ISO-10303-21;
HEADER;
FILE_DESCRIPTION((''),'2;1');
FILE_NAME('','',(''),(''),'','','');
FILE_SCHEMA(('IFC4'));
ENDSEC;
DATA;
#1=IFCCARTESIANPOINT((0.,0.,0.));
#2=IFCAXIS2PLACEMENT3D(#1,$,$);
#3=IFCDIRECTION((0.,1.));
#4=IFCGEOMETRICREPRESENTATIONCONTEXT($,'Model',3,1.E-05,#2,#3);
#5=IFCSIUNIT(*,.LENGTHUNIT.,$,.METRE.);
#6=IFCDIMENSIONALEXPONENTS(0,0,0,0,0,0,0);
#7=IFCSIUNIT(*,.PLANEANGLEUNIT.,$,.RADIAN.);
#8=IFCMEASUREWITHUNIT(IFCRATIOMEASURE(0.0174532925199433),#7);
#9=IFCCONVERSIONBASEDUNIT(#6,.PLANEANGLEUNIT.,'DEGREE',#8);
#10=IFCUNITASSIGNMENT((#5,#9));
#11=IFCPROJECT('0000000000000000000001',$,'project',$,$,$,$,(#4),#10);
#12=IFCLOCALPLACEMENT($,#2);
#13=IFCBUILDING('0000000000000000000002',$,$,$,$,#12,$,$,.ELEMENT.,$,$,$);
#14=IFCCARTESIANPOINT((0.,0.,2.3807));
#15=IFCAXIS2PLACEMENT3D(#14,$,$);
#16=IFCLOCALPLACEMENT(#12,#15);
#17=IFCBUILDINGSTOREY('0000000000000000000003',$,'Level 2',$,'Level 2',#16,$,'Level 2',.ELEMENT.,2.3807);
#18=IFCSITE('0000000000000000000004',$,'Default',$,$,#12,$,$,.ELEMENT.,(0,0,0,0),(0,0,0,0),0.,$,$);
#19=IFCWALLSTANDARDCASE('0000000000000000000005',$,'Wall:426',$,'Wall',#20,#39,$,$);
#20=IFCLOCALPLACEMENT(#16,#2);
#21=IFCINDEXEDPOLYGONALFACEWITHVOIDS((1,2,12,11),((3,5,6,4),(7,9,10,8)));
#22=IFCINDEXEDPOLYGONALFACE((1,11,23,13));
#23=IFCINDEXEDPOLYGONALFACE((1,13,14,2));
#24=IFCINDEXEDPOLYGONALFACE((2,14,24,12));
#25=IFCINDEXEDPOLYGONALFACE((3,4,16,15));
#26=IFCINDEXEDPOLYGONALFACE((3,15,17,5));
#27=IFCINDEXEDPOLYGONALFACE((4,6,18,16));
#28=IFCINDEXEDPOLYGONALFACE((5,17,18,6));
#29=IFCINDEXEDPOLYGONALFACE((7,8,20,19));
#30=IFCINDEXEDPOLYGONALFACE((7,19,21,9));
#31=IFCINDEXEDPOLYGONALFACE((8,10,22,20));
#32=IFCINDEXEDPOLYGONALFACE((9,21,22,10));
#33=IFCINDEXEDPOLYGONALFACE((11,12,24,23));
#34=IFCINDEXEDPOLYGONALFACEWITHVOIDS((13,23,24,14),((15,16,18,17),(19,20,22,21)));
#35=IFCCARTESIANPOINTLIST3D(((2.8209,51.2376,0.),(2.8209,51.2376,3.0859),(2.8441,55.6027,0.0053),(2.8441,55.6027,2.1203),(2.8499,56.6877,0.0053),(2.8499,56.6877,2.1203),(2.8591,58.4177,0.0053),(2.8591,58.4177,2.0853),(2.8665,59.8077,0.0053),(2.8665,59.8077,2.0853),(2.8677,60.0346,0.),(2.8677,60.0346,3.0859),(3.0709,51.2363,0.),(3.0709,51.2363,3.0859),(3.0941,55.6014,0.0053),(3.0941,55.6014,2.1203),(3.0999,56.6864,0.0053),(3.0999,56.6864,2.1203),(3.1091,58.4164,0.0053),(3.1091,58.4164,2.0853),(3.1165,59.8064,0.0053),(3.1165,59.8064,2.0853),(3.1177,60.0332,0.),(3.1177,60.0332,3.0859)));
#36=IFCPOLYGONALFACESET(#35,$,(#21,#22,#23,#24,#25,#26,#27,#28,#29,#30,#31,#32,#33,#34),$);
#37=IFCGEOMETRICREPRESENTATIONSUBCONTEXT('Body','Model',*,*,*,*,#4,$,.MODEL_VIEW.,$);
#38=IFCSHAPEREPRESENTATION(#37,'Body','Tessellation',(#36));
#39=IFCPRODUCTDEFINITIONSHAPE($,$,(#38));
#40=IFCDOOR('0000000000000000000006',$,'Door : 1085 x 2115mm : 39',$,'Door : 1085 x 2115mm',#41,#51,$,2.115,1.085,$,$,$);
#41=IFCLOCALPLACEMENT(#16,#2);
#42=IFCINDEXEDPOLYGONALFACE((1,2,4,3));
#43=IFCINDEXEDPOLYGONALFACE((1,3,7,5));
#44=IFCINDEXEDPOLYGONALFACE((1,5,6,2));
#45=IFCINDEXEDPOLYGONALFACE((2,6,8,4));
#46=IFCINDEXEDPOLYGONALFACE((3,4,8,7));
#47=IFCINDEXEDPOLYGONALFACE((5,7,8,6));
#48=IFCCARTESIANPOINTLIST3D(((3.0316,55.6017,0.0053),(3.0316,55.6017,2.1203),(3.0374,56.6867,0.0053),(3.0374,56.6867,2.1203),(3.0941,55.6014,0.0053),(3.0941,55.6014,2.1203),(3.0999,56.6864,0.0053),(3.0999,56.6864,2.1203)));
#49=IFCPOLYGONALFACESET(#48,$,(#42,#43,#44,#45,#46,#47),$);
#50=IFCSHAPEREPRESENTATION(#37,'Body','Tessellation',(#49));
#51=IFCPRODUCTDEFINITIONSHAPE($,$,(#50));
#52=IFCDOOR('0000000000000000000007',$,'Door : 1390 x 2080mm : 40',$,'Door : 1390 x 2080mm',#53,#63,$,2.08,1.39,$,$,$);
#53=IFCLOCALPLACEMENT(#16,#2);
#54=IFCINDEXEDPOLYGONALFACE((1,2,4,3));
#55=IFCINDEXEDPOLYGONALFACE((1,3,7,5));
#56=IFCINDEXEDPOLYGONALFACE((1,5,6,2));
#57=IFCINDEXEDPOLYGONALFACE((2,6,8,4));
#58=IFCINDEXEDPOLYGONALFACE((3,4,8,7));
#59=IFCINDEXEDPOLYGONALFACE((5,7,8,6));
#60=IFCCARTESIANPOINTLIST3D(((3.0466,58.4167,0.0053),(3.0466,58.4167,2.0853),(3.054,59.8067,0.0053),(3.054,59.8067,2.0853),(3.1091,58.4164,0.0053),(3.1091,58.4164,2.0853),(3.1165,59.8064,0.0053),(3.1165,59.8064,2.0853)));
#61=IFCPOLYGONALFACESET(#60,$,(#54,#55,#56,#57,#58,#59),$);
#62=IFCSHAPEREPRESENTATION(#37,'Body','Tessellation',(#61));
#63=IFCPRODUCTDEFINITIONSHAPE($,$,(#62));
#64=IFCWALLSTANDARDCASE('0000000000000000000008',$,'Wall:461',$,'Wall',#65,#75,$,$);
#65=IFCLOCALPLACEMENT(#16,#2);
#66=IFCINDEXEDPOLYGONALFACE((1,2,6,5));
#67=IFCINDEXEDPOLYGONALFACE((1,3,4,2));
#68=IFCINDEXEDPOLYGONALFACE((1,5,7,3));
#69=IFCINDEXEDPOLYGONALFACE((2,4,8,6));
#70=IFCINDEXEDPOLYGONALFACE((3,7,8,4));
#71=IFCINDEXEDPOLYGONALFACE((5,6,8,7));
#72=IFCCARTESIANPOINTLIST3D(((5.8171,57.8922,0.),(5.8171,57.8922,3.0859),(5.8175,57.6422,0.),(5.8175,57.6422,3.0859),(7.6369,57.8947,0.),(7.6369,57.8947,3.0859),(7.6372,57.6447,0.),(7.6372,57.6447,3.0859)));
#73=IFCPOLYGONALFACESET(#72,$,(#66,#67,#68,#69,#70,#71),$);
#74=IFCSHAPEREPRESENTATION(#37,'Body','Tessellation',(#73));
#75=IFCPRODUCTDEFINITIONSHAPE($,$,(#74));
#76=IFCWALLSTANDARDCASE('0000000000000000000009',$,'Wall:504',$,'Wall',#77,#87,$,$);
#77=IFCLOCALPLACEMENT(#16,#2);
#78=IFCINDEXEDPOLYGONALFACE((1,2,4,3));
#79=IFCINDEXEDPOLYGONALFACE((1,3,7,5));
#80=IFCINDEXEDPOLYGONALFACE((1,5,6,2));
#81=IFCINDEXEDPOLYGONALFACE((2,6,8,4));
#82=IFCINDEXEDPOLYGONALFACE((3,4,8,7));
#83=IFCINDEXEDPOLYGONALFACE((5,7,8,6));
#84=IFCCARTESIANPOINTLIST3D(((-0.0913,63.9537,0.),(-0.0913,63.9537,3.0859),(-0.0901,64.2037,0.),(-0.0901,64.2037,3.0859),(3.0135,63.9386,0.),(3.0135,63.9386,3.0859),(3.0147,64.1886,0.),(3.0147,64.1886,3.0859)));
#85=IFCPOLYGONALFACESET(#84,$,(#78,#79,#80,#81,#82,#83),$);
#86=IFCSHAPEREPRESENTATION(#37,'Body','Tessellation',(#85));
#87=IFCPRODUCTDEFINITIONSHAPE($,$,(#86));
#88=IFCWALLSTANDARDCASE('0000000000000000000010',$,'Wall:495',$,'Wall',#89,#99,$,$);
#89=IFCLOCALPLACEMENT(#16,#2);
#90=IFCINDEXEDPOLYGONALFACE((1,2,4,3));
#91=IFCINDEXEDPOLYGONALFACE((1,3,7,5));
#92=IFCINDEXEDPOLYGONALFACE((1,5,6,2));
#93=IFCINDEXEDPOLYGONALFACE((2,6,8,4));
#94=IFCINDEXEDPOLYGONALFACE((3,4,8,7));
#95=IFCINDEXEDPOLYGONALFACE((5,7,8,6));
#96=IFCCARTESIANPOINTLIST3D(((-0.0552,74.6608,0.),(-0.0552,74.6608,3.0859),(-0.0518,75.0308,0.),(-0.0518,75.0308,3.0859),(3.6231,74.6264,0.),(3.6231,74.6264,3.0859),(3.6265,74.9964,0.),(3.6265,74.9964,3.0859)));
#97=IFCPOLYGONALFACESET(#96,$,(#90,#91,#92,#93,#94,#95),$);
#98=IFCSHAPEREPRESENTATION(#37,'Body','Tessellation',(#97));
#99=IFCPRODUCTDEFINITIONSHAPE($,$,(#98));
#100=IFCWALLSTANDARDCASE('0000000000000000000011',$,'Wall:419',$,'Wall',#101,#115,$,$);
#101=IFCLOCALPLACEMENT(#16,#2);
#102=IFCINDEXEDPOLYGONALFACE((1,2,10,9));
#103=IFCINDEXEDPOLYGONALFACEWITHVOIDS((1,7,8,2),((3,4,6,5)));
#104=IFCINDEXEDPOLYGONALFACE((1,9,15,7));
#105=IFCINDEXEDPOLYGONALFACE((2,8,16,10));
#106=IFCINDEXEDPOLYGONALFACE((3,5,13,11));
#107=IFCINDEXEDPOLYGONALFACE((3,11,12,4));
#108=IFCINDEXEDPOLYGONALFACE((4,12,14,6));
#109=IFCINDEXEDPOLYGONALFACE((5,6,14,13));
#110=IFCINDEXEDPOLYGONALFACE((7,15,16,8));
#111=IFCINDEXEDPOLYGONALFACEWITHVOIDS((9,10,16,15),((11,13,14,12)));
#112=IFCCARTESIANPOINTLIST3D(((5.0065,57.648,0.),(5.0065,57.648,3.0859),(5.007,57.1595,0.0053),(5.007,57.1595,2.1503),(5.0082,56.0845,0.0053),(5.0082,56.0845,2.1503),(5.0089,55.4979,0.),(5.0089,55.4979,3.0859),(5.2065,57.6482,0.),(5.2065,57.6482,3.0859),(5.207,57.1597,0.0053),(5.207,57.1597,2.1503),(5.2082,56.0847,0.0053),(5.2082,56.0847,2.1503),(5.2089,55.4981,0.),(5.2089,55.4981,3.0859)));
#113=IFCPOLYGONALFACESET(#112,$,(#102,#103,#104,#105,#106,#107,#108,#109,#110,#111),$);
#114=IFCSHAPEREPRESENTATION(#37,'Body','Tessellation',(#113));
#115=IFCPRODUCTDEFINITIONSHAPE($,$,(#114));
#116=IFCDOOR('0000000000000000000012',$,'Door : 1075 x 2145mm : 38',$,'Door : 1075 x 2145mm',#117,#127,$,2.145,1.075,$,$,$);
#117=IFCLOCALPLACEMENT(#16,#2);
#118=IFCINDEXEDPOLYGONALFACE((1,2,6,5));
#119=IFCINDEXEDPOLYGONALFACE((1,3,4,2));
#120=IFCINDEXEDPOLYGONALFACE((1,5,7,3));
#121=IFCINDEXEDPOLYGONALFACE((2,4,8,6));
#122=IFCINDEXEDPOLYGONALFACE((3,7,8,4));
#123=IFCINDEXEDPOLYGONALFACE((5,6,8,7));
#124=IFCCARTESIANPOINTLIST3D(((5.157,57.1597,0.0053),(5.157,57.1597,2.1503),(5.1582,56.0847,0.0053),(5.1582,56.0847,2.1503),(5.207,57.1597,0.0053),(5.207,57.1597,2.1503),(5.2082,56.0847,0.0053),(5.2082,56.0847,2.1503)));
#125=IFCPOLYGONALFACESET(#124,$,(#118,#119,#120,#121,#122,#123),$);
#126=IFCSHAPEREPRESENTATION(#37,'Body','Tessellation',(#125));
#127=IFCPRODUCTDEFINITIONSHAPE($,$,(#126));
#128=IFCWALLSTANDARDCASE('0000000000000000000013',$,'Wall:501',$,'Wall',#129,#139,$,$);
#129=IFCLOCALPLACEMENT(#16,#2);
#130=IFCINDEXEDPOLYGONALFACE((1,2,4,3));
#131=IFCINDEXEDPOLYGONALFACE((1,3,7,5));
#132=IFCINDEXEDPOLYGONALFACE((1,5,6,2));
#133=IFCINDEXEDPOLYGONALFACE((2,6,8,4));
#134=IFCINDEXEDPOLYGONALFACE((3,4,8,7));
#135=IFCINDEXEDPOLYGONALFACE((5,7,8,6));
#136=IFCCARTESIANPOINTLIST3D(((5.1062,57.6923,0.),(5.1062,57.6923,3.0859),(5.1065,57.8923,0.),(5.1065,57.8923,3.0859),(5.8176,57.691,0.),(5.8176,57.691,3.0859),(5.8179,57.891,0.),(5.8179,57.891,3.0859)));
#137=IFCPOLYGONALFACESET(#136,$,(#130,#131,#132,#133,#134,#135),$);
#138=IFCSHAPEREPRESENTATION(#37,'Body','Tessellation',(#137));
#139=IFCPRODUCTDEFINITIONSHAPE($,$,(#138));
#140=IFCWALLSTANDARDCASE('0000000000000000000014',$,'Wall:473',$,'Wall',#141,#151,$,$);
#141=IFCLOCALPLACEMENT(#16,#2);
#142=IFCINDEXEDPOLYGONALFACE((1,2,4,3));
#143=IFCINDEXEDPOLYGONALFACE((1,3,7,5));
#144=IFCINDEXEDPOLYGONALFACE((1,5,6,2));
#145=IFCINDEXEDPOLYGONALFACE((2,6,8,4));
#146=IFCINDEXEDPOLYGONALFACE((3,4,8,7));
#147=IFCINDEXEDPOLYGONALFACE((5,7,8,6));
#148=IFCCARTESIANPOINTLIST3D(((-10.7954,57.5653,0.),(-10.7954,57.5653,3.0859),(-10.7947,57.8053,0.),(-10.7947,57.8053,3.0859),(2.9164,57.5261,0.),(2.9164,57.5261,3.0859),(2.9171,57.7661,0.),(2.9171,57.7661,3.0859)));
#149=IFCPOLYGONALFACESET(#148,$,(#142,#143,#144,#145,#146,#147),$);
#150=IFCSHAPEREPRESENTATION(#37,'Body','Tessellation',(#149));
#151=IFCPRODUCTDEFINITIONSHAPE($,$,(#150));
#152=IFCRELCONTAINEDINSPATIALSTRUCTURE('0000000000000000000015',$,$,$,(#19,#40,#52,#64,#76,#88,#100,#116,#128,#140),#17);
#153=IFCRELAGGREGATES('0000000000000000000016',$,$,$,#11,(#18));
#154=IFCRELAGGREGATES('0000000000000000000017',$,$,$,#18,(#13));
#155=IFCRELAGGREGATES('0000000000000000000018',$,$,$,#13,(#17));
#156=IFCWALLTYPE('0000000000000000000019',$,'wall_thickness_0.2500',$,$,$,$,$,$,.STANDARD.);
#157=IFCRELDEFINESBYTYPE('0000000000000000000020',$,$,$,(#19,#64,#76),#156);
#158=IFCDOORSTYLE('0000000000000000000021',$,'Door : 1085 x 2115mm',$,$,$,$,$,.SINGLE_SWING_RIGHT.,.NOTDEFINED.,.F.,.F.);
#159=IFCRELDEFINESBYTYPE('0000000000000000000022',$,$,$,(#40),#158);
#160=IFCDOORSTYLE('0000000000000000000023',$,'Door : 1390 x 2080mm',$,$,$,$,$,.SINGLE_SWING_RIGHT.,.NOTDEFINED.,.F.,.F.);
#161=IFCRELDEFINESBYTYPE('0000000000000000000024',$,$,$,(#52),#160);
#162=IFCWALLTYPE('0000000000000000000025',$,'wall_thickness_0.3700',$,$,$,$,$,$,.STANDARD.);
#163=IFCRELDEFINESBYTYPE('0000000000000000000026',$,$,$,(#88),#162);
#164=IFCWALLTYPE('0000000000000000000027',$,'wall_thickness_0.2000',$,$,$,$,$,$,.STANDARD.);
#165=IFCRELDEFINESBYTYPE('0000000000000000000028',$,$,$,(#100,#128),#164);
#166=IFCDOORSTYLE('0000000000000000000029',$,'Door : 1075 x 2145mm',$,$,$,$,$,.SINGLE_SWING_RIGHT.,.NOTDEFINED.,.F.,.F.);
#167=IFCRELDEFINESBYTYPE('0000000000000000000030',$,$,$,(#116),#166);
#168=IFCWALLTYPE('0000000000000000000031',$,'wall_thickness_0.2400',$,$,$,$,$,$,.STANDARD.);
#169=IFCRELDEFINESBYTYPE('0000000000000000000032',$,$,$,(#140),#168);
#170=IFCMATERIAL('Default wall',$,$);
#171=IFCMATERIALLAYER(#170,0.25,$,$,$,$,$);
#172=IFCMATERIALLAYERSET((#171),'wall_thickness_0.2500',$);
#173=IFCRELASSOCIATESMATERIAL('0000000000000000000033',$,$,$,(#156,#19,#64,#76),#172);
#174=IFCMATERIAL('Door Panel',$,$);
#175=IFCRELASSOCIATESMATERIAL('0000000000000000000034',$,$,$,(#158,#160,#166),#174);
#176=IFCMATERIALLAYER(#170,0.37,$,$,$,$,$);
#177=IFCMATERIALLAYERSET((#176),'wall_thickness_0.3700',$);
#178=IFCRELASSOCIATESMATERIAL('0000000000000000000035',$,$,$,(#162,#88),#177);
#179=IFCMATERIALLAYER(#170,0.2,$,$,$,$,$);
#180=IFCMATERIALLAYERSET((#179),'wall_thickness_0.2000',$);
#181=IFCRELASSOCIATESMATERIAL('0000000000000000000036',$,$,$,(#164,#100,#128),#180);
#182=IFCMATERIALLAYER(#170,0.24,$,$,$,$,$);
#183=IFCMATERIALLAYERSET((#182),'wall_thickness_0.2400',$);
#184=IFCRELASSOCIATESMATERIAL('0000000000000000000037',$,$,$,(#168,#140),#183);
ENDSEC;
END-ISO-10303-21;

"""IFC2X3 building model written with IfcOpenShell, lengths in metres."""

from ifc_helpers import new_model, entity, si_unit, converted_unit, direction, frame, frame_2d, origin, origin_2d_with_axis, place, context, subcontext, project, spatial, polyline, rectangle, outline, extrude, source, transform, mapped, material, layer, layer_set, layer_usage, type_object, type_shapes, element, fill, save


model = new_model("IFC2X3")

# Units and contexts
model_context = context("Model", 3, precision=1e-05, world=origin(), true_north=direction((0.0, 1.0)))
body_context = subcontext(model_context, "Body", "Model", "MODEL_VIEW")
ifc_project = project(units=[si_unit("LENGTHUNIT", "METRE"), converted_unit("PLANEANGLEUNIT", "DEGREE", entity("IfcRatioMeasure", 0.0174532925199433), si_unit("PLANEANGLEUNIT", "RADIAN"), dimensions=[0, 0, 0, 0, 0, 0, 0])], contexts=[model_context])

# Site, building, storey
placement_1 = place(None, origin())
site = spatial("IfcSite", under=ifc_project, at=placement_1, Name="Default", CompositionType="ELEMENT", RefLatitude=(0, 0, 0, 0), RefLongitude=(0, 0, 0, 0), RefElevation=0.0)
building = spatial("IfcBuilding", under=site, at=placement_1, CompositionType="ELEMENT")
storey_placement = place(placement_1, frame((0.0, 0.0, 2.3807)))
storey = spatial("IfcBuildingStorey", under=building, at=storey_placement, Name="Level 2", ObjectType="Level 2", LongName="Level 2", CompositionType="ELEMENT", Elevation=2.3807)

# Shared definitions
ifc_material_1 = material(Name="Default wall")

# Shared definitions
ifc_layer_1 = layer(ifc_material_1, 0.25)
ifc_layer_set_1 = layer_set([ifc_layer_1], Name="wall_thickness_0.2500")
ifc_layer_usage_1 = layer_usage(ifc_layer_set_1, "AXIS2", "POSITIVE", -0.125)
wall_type_1 = type_object("IfcWallType", Name="wall_thickness_0.2500", PredefinedType="STANDARD", material=ifc_layer_set_1)
ifc_material_2 = material(Name="Door Panel")

# Wall, openings, doors
wall_1_placement = place(storey_placement, frame((2.9927, 60.0339, 0.0), z_axis=(0.0, 0.0, 1.0), x_axis=(-0.005312, -0.999986, 0.0)))
wall_1 = element("IfcWallStandardCase", 1, at=wall_1_placement, inside=storey, type_object=wall_type_1, material=ifc_layer_usage_1, Name="Wall:426", ObjectType="Wall", context=body_context, shape_type="SweptSolid", body=[
    extrude(outline(polyline([(8.7971, -0.125), (8.7971, 0.125), (0.0, 0.125), (0.0, -0.125), (8.7971, -0.125)])), origin(), (0.0, 0.0, 1.0), 3.0859),
])
opening_1_placement = place(wall_1_placement, frame((3.3469, -0.125, 0.0053)))
opening_1 = element("IfcOpeningElement", 2, at=opening_1_placement, cuts=wall_1, ObjectType="Opening", context=body_context, shape_type="SweptSolid", body=[
    extrude(rectangle(XDim=1.085, YDim=2.115, at=frame_2d((1.0575, 0.5425), x_axis=(0.0, 1.0))), frame((0.0, 0.0, 0.0), z_axis=(0.0, 1.0, 0.0), x_axis=(0.0, 0.0, 1.0)), (0.0, 0.0, 1.0), 0.25),
])
opening_2_placement = place(wall_1_placement, frame((0.2268, -0.125, 0.0053)))
opening_2 = element("IfcOpeningElement", 3, at=opening_2_placement, cuts=wall_1, ObjectType="Opening", context=body_context, shape_type="SweptSolid", body=[
    extrude(rectangle(XDim=1.39, YDim=2.08, at=frame_2d((1.04, 0.695), x_axis=(0.0, 1.0))), frame((0.0, 0.0, 0.0), z_axis=(0.0, 1.0, 0.0), x_axis=(0.0, 0.0, 1.0)), (0.0, 0.0, 1.0), 0.25),
])
door_style_1 = type_object("IfcDoorStyle", Name="Door : 1085 x 2115mm", ConstructionType="NOTDEFINED", OperationType="SINGLE_SWING_RIGHT", ParameterTakesPrecedence=False, Sizeable=False, material=ifc_material_2)
shared_shape_1 = source(origin(), body_context, "Body", "SweptSolid", [
    extrude(rectangle(XDim=0.0625, YDim=1.085, at=origin_2d_with_axis()), frame((0.5425, 0.2188, 0.0), z_axis=(0.0, 0.0, 1.0), x_axis=(0.0, 1.0, 0.0)), (0.0, 0.0, 1.0), 2.115),
])
type_shapes(door_style_1, [shared_shape_1])
door_1_placement = place(opening_1_placement, origin())
door_1 = element("IfcDoor", 4, at=door_1_placement, inside=storey, type_object=door_style_1, Name="Door : 1085 x 2115mm : 39", ObjectType="Door : 1085 x 2115mm", OverallHeight=2.115, OverallWidth=1.085, context=body_context, shape_type="MappedRepresentation", body=[
    mapped(shared_shape_1, transform((0.0, 0.0, 0.0), scale=1.0)),
])
fill(opening_1, door_1)
door_style_2 = type_object("IfcDoorStyle", Name="Door : 1390 x 2080mm", ConstructionType="NOTDEFINED", OperationType="SINGLE_SWING_RIGHT", ParameterTakesPrecedence=False, Sizeable=False, material=ifc_material_2)
shared_shape_2 = source(origin(), body_context, "Body", "SweptSolid", [
    extrude(rectangle(XDim=0.0625, YDim=1.39, at=origin_2d_with_axis()), frame((0.695, 0.2188, 0.0), z_axis=(0.0, 0.0, 1.0), x_axis=(0.0, 1.0, 0.0)), (0.0, 0.0, 1.0), 2.08),
])
type_shapes(door_style_2, [shared_shape_2])
door_2_placement = place(opening_2_placement, origin())
door_2 = element("IfcDoor", 5, at=door_2_placement, inside=storey, type_object=door_style_2, Name="Door : 1390 x 2080mm : 40", ObjectType="Door : 1390 x 2080mm", OverallHeight=2.08, OverallWidth=1.39, context=body_context, shape_type="MappedRepresentation", body=[
    mapped(shared_shape_2, transform((0.0, 0.0, 0.0), scale=1.0)),
])
fill(opening_2, door_2)

# Walls
wall_2_placement = place(storey_placement, frame((5.8173, 57.7672, 0.0), z_axis=(0.0, 0.0, 1.0), x_axis=(0.999999, 0.001375, 0.0)))
element("IfcWallStandardCase", 6, at=wall_2_placement, inside=storey, type_object=wall_type_1, material=ifc_layer_usage_1, Name="Wall:461", ObjectType="Wall", context=body_context, shape_type="SweptSolid", body=[
    extrude(outline(polyline([(1.8197, -0.125), (1.8197, 0.125), (0.0, 0.125), (0.0, -0.125), (1.8197, -0.125)])), origin(), (0.0, 0.0, 1.0), 3.0859),
])
wall_3_placement = place(storey_placement, frame((-0.0907, 64.0787, 0.0), z_axis=(0.0, 0.0, 1.0), x_axis=(0.999988, -0.004875, 0.0)))
element("IfcWallStandardCase", 7, at=wall_3_placement, inside=storey, type_object=wall_type_1, material=ifc_layer_usage_1, Name="Wall:504", ObjectType="Wall", context=body_context, shape_type="SweptSolid", body=[
    extrude(outline(polyline([(3.1048, -0.125), (3.1048, 0.125), (0.0, 0.125), (0.0, -0.125), (3.1048, -0.125)])), origin(), (0.0, 0.0, 1.0), 3.0859),
])
ifc_layer_2 = layer(ifc_material_1, 0.37)
ifc_layer_set_2 = layer_set([ifc_layer_2], Name="wall_thickness_0.3700")
ifc_layer_usage_2 = layer_usage(ifc_layer_set_2, "AXIS2", "POSITIVE", -0.185)
wall_type_2 = type_object("IfcWallType", Name="wall_thickness_0.3700", PredefinedType="STANDARD", material=ifc_layer_set_2)
wall_4_placement = place(storey_placement, frame((-0.0535, 74.8458, 0.0), z_axis=(0.0, 0.0, 1.0), x_axis=(0.999956, -0.00935, 0.0)))
element("IfcWallStandardCase", 8, at=wall_4_placement, inside=storey, type_object=wall_type_2, material=ifc_layer_usage_2, Name="Wall:495", ObjectType="Wall", context=body_context, shape_type="SweptSolid", body=[
    extrude(outline(polyline([(3.6785, -0.185), (3.6785, 0.185), (0.0, 0.185), (0.0, -0.185), (3.6785, -0.185)])), origin(), (0.0, 0.0, 1.0), 3.0859),
])

# Wall, opening, door
ifc_layer_3 = layer(ifc_material_1, 0.2)
ifc_layer_set_3 = layer_set([ifc_layer_3], Name="wall_thickness_0.2000")
ifc_layer_usage_3 = layer_usage(ifc_layer_set_3, "AXIS2", "POSITIVE", -0.1)
wall_type_3 = type_object("IfcWallType", Name="wall_thickness_0.2000", PredefinedType="STANDARD", material=ifc_layer_set_3)
wall_5_placement = place(storey_placement, frame((5.1065, 57.6481, 0.0), z_axis=(0.0, 0.0, 1.0), x_axis=(0.001117, -0.999999, 0.0)))
wall_5 = element("IfcWallStandardCase", 9, at=wall_5_placement, inside=storey, type_object=wall_type_3, material=ifc_layer_usage_3, Name="Wall:419", ObjectType="Wall", context=body_context, shape_type="SweptSolid", body=[
    extrude(outline(polyline([(2.1501, -0.1), (2.1501, 0.1), (0.0, 0.1), (0.0, -0.1), (2.1501, -0.1)])), origin(), (0.0, 0.0, 1.0), 3.0859),
])
opening_3_placement = place(wall_5_placement, frame((0.4885, -0.1, 0.0053)))
opening_3 = element("IfcOpeningElement", 10, at=opening_3_placement, cuts=wall_5, ObjectType="Opening", context=body_context, shape_type="SweptSolid", body=[
    extrude(rectangle(XDim=1.075, YDim=2.145, at=frame_2d((1.0725, 0.5375), x_axis=(0.0, 1.0))), frame((0.0, 0.0, 0.0), z_axis=(0.0, 1.0, 0.0), x_axis=(0.0, 0.0, 1.0)), (0.0, 0.0, 1.0), 0.2),
])
door_style_3 = type_object("IfcDoorStyle", Name="Door : 1075 x 2145mm", ConstructionType="NOTDEFINED", OperationType="SINGLE_SWING_RIGHT", ParameterTakesPrecedence=False, Sizeable=False, material=ifc_material_2)
shared_shape_3 = source(origin(), body_context, "Body", "SweptSolid", [
    extrude(rectangle(XDim=0.05, YDim=1.075, at=origin_2d_with_axis()), frame((0.5375, 0.175, 0.0), z_axis=(0.0, 0.0, 1.0), x_axis=(0.0, 1.0, 0.0)), (0.0, 0.0, 1.0), 2.145),
])
type_shapes(door_style_3, [shared_shape_3])
door_3_placement = place(opening_3_placement, origin())
door_3 = element("IfcDoor", 11, at=door_3_placement, inside=storey, type_object=door_style_3, Name="Door : 1075 x 2145mm : 38", ObjectType="Door : 1075 x 2145mm", OverallHeight=2.145, OverallWidth=1.075, context=body_context, shape_type="MappedRepresentation", body=[
    mapped(shared_shape_3, transform((0.0, 0.0, 0.0), scale=1.0)),
])
fill(opening_3, door_3)

# Walls
wall_6_placement = place(storey_placement, frame((5.1063, 57.7923, 0.0), z_axis=(0.0, 0.0, 1.0), x_axis=(0.999998, -0.001786, 0.0)))
element("IfcWallStandardCase", 12, at=wall_6_placement, inside=storey, type_object=wall_type_3, material=ifc_layer_usage_3, Name="Wall:501", ObjectType="Wall", context=body_context, shape_type="SweptSolid", body=[
    extrude(outline(polyline([(0.7114, -0.1), (0.7114, 0.1), (0.0, 0.1), (0.0, -0.1), (0.7114, -0.1)])), origin(), (0.0, 0.0, 1.0), 3.0859),
])
ifc_layer_4 = layer(ifc_material_1, 0.24)
ifc_layer_set_4 = layer_set([ifc_layer_4], Name="wall_thickness_0.2400")
ifc_layer_usage_4 = layer_usage(ifc_layer_set_4, "AXIS2", "POSITIVE", -0.12)
wall_type_4 = type_object("IfcWallType", Name="wall_thickness_0.2400", PredefinedType="STANDARD", material=ifc_layer_set_4)
wall_7_placement = place(storey_placement, frame((-10.795, 57.6853, 0.0), z_axis=(0.0, 0.0, 1.0), x_axis=(0.999996, -0.002857, 0.0)))
element("IfcWallStandardCase", 13, at=wall_7_placement, inside=storey, type_object=wall_type_4, material=ifc_layer_usage_4, Name="Wall:473", ObjectType="Wall", context=body_context, shape_type="SweptSolid", body=[
    extrude(outline(polyline([(13.7118, -0.12), (13.7118, 0.12), (0.0, 0.12), (0.0, -0.12), (13.7118, -0.12)])), origin(), (0.0, 0.0, 1.0), 3.0859),
])

save(model, "model.ifc")
